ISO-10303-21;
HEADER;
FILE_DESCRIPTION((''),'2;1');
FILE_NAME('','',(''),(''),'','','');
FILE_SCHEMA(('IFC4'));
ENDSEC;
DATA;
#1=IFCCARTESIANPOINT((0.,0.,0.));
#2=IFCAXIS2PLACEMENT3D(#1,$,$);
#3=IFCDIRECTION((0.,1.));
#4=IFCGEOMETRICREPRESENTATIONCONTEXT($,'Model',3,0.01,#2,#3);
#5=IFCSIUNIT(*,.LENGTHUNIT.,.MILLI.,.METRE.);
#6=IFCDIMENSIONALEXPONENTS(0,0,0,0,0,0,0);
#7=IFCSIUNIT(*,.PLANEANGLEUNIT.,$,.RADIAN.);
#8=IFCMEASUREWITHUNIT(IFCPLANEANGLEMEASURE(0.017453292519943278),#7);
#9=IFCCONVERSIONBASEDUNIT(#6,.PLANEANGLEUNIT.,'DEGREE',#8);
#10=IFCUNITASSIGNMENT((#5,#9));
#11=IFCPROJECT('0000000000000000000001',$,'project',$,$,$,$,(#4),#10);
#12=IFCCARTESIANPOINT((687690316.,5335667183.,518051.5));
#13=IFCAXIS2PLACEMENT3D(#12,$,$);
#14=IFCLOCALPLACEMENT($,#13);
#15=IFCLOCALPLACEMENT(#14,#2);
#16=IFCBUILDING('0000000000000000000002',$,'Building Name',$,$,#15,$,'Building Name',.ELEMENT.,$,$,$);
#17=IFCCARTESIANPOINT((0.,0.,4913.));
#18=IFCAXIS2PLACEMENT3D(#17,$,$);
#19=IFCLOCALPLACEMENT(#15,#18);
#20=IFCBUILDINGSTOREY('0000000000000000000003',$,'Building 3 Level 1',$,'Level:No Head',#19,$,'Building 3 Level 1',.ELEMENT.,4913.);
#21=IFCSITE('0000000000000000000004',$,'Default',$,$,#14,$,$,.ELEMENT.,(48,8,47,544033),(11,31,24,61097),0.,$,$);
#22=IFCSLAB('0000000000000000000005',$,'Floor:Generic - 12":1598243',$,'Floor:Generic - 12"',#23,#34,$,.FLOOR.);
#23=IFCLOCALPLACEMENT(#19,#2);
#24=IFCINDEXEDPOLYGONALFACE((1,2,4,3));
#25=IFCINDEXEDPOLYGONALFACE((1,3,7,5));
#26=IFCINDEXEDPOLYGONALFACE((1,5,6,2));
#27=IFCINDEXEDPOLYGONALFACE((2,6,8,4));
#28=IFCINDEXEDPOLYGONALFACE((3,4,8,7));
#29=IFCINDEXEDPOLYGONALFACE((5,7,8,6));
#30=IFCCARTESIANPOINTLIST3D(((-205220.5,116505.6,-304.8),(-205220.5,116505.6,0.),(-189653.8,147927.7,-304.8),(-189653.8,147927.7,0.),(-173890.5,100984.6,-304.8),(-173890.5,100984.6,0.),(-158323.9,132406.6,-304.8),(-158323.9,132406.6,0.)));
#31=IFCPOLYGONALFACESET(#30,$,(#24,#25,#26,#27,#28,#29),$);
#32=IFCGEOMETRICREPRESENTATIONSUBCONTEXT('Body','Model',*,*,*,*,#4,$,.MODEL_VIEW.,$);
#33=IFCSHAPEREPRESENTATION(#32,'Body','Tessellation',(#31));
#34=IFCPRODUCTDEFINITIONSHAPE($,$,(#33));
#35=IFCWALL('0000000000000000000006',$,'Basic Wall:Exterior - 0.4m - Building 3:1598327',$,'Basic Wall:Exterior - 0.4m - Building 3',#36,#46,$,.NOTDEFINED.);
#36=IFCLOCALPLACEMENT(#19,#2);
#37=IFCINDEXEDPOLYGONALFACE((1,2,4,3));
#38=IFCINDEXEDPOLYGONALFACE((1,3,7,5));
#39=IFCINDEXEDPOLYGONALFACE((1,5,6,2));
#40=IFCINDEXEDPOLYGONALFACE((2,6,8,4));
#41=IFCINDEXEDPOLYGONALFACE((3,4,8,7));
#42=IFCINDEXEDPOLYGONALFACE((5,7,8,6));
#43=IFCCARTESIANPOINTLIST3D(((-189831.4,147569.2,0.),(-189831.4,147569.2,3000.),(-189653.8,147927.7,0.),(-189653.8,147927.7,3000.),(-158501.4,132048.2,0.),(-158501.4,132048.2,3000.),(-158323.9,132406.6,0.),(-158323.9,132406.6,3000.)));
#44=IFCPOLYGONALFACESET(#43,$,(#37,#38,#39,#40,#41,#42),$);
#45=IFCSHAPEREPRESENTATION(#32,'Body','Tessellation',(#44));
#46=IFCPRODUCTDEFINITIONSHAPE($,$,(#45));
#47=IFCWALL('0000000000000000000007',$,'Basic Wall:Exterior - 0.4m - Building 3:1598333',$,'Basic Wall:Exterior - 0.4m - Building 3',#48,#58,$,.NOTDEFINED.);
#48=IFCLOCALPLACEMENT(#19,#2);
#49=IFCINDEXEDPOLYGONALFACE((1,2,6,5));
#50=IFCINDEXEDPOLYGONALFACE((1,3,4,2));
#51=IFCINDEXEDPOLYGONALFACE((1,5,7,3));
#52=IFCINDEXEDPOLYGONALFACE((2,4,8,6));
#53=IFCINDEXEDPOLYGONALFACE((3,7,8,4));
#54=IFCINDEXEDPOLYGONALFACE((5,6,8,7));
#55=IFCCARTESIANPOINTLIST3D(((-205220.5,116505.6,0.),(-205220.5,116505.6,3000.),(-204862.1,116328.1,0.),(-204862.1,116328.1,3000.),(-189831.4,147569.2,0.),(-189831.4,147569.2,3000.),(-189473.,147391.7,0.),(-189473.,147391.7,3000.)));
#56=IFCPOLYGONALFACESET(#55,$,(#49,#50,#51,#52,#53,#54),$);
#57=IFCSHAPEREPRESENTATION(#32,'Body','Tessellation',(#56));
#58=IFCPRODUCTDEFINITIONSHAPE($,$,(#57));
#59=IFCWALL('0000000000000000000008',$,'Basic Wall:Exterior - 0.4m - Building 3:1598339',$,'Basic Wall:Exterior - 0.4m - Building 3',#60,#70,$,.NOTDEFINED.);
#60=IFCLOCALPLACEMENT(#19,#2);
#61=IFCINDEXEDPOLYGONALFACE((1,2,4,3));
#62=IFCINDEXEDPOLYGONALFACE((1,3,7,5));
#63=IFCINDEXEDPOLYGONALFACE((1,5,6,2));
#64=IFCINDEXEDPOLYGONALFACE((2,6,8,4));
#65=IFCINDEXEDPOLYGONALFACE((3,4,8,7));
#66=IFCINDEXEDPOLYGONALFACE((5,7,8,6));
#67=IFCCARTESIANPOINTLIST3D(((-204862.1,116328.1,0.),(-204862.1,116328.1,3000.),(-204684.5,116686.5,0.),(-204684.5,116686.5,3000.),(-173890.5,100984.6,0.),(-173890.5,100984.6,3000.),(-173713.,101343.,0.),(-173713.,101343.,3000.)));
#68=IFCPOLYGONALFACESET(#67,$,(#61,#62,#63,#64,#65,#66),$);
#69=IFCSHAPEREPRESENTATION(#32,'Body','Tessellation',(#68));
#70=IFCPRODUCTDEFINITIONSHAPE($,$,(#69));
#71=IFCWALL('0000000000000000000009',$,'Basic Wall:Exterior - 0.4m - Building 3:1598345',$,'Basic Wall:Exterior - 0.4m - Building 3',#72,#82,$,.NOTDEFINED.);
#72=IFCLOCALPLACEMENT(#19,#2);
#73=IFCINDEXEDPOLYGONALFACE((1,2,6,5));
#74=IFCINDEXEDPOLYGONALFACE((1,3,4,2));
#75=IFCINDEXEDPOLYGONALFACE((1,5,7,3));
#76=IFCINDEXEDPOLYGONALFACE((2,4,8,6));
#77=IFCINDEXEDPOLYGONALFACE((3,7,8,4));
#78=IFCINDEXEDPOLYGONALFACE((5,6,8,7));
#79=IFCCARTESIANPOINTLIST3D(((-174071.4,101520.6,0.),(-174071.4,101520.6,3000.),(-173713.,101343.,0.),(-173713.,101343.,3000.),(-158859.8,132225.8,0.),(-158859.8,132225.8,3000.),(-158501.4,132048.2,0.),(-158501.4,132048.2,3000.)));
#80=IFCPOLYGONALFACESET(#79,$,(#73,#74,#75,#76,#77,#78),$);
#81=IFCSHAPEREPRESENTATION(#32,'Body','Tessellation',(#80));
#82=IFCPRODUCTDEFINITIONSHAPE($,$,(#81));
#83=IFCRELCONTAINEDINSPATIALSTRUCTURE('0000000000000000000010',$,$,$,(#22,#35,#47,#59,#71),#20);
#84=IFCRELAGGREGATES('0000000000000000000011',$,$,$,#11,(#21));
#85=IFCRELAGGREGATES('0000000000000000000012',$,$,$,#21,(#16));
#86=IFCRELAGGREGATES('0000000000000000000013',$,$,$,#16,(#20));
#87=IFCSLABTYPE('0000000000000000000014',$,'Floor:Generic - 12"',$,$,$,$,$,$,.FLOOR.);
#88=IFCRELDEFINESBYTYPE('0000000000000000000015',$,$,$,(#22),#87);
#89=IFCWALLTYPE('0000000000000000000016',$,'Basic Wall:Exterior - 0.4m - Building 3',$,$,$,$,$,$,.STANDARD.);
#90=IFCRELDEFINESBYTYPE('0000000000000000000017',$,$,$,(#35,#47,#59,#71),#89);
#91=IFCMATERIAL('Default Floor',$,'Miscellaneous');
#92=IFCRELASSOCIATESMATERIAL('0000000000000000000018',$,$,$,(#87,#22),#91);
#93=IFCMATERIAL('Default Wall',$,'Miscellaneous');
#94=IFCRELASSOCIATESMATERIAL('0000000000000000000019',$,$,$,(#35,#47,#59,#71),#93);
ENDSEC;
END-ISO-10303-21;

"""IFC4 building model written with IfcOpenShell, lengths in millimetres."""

from ifc_helpers import new_model, entity, si_unit, converted_unit, direction, frame, origin, place, context, subcontext, project, spatial, indexed_curve, outline, extrude, material, type_object, element, save


model = new_model("IFC4")

# Units and contexts
model_context = context("Model", 3, precision=0.01, world=origin(), true_north=direction((0.0, 1.0)))
body_context = subcontext(model_context, "Body", "Model", "MODEL_VIEW")
ifc_project = project(units=[si_unit("LENGTHUNIT", "METRE", prefix="MILLI"), converted_unit("PLANEANGLEUNIT", "DEGREE", entity("IfcPlaneAngleMeasure", 0.017453292519943278), si_unit("PLANEANGLEUNIT", "RADIAN"), dimensions=[0, 0, 0, 0, 0, 0, 0])], contexts=[model_context])

# Site, building, storey
site_placement = place(None, frame((687690316.0, 5335667183.0, 518051.5)))
site = spatial("IfcSite", under=ifc_project, at=site_placement, Name="Default", CompositionType="ELEMENT", RefLatitude=(48, 8, 47, 544033), RefLongitude=(11, 31, 24, 61097), RefElevation=0.0)
building_placement = place(site_placement, origin())
building = spatial("IfcBuilding", under=site, at=building_placement, Name="Building Name", LongName="Building Name", CompositionType="ELEMENT")
storey_placement = place(building_placement, frame((0.0, 0.0, 4913.0)))
storey = spatial("IfcBuildingStorey", under=building, at=storey_placement, Name="Building 3 Level 1", ObjectType="Level:No Head", LongName="Building 3 Level 1", CompositionType="ELEMENT", Elevation=4913.0)

# Slab
ifc_material_1 = material(Name="Default Floor", Category="Miscellaneous")
slab_type = type_object("IfcSlabType", Name="Floor:Generic - 12\"", PredefinedType="FLOOR", material=ifc_material_1)
slab_placement = place(storey_placement, origin())
element("IfcSlab", 1, at=slab_placement, inside=storey, type_object=slab_type, material=ifc_material_1, Name="Floor:Generic - 12\":1598243", ObjectType="Floor:Generic - 12\"", PredefinedType="FLOOR", context=body_context, shape_type="SweptSolid", body=[
    extrude(outline(indexed_curve([(-17533.3, -17481.9), (17533.3, -17481.9), (17533.3, 17481.9), (-17533.3, 17481.9), (-17533.3, -17481.9)], self_intersect=False)), frame((-181772.2, 124456.1, 0.0), z_axis=(0.0, 0.0, -1.0), x_axis=(-0.443917, -0.896068, 0.0)), (0.0, 0.0, 1.0), 304.8),
])

# Walls
ifc_material_2 = material(Name="Default Wall", Category="Miscellaneous")
wall_type = type_object("IfcWallType", Name="Basic Wall:Exterior - 0.4m - Building 3", PredefinedType="STANDARD")
wall_1_placement = place(storey_placement, frame((-158412.6, 132227.4, 0.0), z_axis=(0.0, 0.0, 1.0), x_axis=(-0.896068, 0.443917, 0.0)))
element("IfcWall", 2, at=wall_1_placement, inside=storey, type_object=wall_type, material=ifc_material_2, Name="Basic Wall:Exterior - 0.4m - Building 3:1598327", ObjectType="Basic Wall:Exterior - 0.4m - Building 3", PredefinedType="NOTDEFINED", context=body_context, shape_type="SweptSolid", body=[
    extrude(outline(indexed_curve([(34963.8, 200.0), (0.0, 200.0), (0.0, -200.0), (34963.8, -200.0), (34963.8, 200.0)], self_intersect=False)), origin(), (0.0, 0.0, 1.0), 3000.0),
])
wall_2_placement = place(storey_placement, frame((-189652.2, 147480.5, 0.0), z_axis=(0.0, 0.0, 1.0), x_axis=(-0.443917, -0.896068, 0.0)))
element("IfcWall", 3, at=wall_2_placement, inside=storey, type_object=wall_type, material=ifc_material_2, Name="Basic Wall:Exterior - 0.4m - Building 3:1598333", ObjectType="Basic Wall:Exterior - 0.4m - Building 3", PredefinedType="NOTDEFINED", context=body_context, shape_type="SweptSolid", body=[
    extrude(outline(indexed_curve([(34666.6, 200.0), (0.0, 200.0), (0.0, -200.0), (34666.6, -200.0), (34666.6, 200.0)], self_intersect=False)), origin(), (0.0, 0.0, 1.0), 3000.0),
])
wall_3_placement = place(storey_placement, frame((-204773.3, 116507.3, 0.0), z_axis=(0.0, 0.0, 1.0), x_axis=(0.896068, -0.443917, 0.0)))
element("IfcWall", 4, at=wall_3_placement, inside=storey, type_object=wall_type, material=ifc_material_2, Name="Basic Wall:Exterior - 0.4m - Building 3:1598339", ObjectType="Basic Wall:Exterior - 0.4m - Building 3", PredefinedType="NOTDEFINED", context=body_context, shape_type="SweptSolid", body=[
    extrude(outline(indexed_curve([(34563.8, 200.0), (0.0, 200.0), (0.0, -200.0), (34563.8, -200.0), (34563.8, 200.0)], self_intersect=False)), origin(), (0.0, 0.0, 1.0), 3000.0),
])
wall_4_placement = place(storey_placement, frame((-173892.2, 101431.8, 0.0), z_axis=(0.0, 0.0, 1.0), x_axis=(0.443917, 0.896068, 0.0)))
element("IfcWall", 5, at=wall_4_placement, inside=storey, type_object=wall_type, material=ifc_material_2, Name="Basic Wall:Exterior - 0.4m - Building 3:1598345", ObjectType="Basic Wall:Exterior - 0.4m - Building 3", PredefinedType="NOTDEFINED", context=body_context, shape_type="SweptSolid", body=[
    extrude(outline(indexed_curve([(34266.6, 200.0), (0.0, 200.0), (0.0, -200.0), (34266.6, -200.0), (34266.6, 200.0)], self_intersect=False)), origin(), (0.0, 0.0, 1.0), 3000.0),
])

save(model, "model.ifc")
